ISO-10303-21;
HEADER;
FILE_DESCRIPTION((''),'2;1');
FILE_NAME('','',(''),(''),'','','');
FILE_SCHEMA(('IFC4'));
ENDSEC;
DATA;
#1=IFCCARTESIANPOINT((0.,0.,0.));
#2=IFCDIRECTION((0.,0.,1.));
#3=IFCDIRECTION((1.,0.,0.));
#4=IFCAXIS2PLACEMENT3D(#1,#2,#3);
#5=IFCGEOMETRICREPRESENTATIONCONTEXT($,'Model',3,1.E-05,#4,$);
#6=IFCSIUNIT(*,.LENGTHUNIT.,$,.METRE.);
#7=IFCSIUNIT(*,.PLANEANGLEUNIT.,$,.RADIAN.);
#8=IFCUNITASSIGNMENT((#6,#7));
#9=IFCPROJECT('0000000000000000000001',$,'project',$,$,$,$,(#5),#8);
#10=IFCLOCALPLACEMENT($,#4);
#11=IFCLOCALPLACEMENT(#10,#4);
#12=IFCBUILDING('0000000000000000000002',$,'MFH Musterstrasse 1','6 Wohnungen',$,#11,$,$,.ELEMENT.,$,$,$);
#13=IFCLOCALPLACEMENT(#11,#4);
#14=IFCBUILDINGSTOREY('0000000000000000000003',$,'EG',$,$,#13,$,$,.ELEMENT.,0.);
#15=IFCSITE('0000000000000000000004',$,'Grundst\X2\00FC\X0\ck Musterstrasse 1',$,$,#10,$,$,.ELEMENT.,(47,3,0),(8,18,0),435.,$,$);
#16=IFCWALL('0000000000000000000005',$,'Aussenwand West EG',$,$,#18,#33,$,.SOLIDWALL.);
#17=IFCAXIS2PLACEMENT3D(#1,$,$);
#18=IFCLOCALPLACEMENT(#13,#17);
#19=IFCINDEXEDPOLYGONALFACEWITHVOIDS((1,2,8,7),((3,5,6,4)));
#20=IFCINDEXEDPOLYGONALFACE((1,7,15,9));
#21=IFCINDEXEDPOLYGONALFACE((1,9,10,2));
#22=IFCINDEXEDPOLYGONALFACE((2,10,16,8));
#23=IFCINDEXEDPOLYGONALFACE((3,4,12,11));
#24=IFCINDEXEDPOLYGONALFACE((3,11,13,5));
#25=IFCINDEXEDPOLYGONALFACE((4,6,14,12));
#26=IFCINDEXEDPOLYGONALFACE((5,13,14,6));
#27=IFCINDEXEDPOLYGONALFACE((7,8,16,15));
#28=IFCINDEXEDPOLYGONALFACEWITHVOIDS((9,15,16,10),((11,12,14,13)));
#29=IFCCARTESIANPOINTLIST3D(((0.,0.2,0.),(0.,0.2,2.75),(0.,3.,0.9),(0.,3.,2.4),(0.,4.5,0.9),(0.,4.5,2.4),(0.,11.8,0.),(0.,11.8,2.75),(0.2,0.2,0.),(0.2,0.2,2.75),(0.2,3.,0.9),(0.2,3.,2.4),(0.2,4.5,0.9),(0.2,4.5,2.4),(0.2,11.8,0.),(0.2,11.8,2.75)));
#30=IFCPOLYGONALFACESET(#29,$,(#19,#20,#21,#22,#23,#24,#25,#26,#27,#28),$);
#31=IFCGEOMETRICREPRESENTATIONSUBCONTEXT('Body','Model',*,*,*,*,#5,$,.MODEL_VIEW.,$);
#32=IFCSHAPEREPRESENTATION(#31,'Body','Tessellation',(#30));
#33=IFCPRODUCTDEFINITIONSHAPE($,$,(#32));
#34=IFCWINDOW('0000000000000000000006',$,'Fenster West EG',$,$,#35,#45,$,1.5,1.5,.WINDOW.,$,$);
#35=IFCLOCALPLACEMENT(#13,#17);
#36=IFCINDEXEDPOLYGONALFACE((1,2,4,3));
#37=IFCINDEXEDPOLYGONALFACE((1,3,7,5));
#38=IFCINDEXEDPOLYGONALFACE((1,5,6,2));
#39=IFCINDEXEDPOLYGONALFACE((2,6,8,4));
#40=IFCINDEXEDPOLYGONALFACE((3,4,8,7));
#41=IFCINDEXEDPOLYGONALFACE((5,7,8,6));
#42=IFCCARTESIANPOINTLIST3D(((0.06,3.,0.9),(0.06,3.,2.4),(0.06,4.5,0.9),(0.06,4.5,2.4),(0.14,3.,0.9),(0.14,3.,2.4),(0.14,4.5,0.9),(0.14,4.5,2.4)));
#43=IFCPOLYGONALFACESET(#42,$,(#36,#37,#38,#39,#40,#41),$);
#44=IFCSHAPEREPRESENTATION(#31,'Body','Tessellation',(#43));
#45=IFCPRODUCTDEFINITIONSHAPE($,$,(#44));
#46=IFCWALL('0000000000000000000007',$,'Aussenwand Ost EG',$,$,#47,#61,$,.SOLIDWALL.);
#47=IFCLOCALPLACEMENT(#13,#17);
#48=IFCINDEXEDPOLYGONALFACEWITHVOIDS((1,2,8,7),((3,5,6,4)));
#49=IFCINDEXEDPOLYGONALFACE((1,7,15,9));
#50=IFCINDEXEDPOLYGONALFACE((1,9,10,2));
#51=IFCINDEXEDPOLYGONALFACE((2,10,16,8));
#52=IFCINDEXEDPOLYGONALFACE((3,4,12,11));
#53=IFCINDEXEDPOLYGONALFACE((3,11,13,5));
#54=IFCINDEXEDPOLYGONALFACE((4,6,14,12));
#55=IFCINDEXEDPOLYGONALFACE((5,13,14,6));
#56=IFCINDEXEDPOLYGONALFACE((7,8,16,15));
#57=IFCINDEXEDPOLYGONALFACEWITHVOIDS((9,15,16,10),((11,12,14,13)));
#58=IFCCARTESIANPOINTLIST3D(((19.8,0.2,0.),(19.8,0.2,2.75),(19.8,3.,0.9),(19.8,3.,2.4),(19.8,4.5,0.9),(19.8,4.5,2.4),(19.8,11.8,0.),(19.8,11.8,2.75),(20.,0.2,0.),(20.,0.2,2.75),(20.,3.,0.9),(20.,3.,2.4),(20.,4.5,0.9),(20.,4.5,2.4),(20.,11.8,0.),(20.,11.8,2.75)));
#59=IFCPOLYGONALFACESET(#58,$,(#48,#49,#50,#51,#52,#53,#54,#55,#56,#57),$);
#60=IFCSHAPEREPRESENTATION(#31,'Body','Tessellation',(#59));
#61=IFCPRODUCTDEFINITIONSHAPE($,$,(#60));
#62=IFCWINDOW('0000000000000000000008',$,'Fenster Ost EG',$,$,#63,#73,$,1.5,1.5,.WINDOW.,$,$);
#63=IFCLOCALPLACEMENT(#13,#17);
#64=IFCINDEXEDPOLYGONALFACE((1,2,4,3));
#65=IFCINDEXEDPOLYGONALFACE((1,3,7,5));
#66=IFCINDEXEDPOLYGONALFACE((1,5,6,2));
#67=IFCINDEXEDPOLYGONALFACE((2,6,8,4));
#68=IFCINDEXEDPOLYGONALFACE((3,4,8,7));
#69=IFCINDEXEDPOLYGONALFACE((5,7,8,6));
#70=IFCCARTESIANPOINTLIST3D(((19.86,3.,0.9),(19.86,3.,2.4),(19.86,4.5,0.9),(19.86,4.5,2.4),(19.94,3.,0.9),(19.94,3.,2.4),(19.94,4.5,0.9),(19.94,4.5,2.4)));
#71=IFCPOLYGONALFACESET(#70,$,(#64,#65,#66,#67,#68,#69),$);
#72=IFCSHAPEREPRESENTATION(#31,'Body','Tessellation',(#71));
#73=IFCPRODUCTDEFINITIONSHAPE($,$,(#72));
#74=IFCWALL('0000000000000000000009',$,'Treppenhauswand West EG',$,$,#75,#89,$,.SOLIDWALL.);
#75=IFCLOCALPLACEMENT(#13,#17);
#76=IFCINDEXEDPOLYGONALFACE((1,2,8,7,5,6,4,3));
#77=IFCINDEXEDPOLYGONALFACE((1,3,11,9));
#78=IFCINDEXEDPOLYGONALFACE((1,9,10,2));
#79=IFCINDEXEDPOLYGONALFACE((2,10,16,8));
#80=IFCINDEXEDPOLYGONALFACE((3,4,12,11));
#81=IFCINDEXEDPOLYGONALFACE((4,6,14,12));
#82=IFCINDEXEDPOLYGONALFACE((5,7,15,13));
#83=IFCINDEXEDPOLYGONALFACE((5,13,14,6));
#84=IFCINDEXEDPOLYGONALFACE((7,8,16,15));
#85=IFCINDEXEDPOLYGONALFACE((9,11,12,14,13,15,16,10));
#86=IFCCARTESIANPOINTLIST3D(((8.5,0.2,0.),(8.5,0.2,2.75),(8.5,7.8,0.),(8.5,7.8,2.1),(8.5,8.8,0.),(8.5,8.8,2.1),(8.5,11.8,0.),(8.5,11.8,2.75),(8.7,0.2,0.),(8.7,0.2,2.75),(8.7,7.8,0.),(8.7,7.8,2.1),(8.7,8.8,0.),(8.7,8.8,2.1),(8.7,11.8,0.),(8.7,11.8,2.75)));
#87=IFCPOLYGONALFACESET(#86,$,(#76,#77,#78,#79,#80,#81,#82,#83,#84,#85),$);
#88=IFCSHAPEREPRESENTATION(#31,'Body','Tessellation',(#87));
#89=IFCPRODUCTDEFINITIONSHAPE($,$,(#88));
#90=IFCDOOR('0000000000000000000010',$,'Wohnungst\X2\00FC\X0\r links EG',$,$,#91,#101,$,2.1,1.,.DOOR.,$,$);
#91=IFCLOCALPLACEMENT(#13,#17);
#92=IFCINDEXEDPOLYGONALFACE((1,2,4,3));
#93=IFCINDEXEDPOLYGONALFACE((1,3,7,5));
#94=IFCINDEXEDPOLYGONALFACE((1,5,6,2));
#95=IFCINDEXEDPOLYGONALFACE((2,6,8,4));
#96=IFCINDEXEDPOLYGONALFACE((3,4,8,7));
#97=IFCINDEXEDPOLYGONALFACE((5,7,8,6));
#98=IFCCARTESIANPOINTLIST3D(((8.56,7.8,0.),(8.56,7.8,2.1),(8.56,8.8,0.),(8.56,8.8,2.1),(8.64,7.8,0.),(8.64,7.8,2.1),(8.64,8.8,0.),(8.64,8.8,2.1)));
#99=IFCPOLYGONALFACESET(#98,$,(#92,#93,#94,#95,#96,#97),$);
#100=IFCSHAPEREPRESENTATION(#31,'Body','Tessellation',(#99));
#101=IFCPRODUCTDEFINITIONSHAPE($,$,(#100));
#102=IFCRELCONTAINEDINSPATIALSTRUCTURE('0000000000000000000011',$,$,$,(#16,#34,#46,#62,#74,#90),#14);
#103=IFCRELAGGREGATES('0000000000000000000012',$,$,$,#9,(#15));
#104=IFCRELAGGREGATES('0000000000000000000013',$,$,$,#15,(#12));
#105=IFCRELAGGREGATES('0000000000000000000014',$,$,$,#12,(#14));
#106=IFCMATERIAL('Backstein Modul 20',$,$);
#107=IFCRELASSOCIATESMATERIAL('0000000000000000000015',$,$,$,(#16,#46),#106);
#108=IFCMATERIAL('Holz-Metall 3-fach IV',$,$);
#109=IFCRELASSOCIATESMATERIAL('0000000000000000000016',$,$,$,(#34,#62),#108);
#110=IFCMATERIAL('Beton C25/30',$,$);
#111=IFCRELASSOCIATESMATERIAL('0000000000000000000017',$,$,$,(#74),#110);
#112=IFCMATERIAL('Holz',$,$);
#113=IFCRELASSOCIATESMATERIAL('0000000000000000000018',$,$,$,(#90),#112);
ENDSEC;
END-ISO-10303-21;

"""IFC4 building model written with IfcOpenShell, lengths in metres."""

from ifc_helpers import new_model, si_unit, frame, frame_2d, origin_with_axes, place, context, subcontext, project, spatial, rectangle, extrude, material, element, fill, save


model = new_model("IFC4")

# Units and contexts
model_context = context("Model", 3, precision=1e-05, world=origin_with_axes())
body_context = subcontext(model_context, "Body", "Model", "MODEL_VIEW")
ifc_project = project(units=[si_unit("LENGTHUNIT", "METRE"), si_unit("PLANEANGLEUNIT", "RADIAN")], contexts=[model_context])

# Site, building, storey
site_placement = place(None, origin_with_axes())
site = spatial("IfcSite", under=ifc_project, at=site_placement, Name="Grundstück Musterstrasse 1", CompositionType="ELEMENT", RefLatitude=(47, 3, 0), RefLongitude=(8, 18, 0), RefElevation=435.0)
building_placement = place(site_placement, origin_with_axes())
building = spatial("IfcBuilding", under=site, at=building_placement, Name="MFH Musterstrasse 1", Description="6 Wohnungen", CompositionType="ELEMENT")
storey_placement = place(building_placement, origin_with_axes())
storey = spatial("IfcBuildingStorey", under=building, at=storey_placement, Name="EG", CompositionType="ELEMENT", Elevation=0.0)

# Walls, openings, windows
ifc_material_1 = material(Name="Backstein Modul 20")
wall_1_placement = place(storey_placement, origin_with_axes())
wall_1 = element("IfcWall", 1, at=wall_1_placement, inside=storey, material=ifc_material_1, Name="Aussenwand West EG", PredefinedType="SOLIDWALL", context=body_context, shape_type="SweptSolid", body=[
    extrude(rectangle(XDim=0.2, YDim=11.6, at=frame_2d((0.1, 5.8), x_axis=(1.0, 0.0))), frame((0.0, 0.2, 0.0), z_axis=(0.0, 0.0, 1.0), x_axis=(1.0, 0.0, 0.0)), (0.0, 0.0, 1.0), 2.75),
])
opening_1_placement = place(storey_placement, origin_with_axes())
element("IfcOpeningElement", 2, at=opening_1_placement, cuts=wall_1, PredefinedType="OPENING", context=body_context, shape_type="SweptSolid", body=[
    extrude(rectangle(XDim=0.3, YDim=1.5, at=frame_2d((0.15, 0.75), x_axis=(1.0, 0.0))), frame((-0.05, 3.0, 0.9), z_axis=(0.0, 0.0, 1.0), x_axis=(1.0, 0.0, 0.0)), (0.0, 0.0, 1.0), 1.5),
])
opening_2_placement = place(storey_placement, origin_with_axes())
opening_2 = element("IfcOpeningElement", 3, at=opening_2_placement, cuts=wall_1, PredefinedType="OPENING", context=body_context, shape_type="SweptSolid", body=[
    extrude(rectangle(XDim=0.22, YDim=1.5, at=frame_2d((0.11, 0.75), x_axis=(1.0, 0.0))), frame((-0.01, 3.0, 0.9), z_axis=(0.0, 0.0, 1.0), x_axis=(1.0, 0.0, 0.0)), (0.0, 0.0, 1.0), 1.5),
])
ifc_material_2 = material(Name="Holz-Metall 3-fach IV")
window_1_placement = place(storey_placement, origin_with_axes())
window_1 = element("IfcWindow", 4, at=window_1_placement, inside=storey, material=ifc_material_2, Name="Fenster West EG", OverallHeight=1.5, OverallWidth=1.5, PredefinedType="WINDOW", context=body_context, shape_type="SweptSolid", body=[
    extrude(rectangle(XDim=0.08, YDim=1.5, at=frame_2d((0.04, 0.75), x_axis=(1.0, 0.0))), frame((0.06, 3.0, 0.9), z_axis=(0.0, 0.0, 1.0), x_axis=(1.0, 0.0, 0.0)), (0.0, 0.0, 1.0), 1.5),
])
fill(opening_2, window_1)
wall_2_placement = place(storey_placement, origin_with_axes())
wall_2 = element("IfcWall", 5, at=wall_2_placement, inside=storey, material=ifc_material_1, Name="Aussenwand Ost EG", PredefinedType="SOLIDWALL", context=body_context, shape_type="SweptSolid", body=[
    extrude(rectangle(XDim=0.2, YDim=11.6, at=frame_2d((0.1, 5.8), x_axis=(1.0, 0.0))), frame((19.8, 0.2, 0.0), z_axis=(0.0, 0.0, 1.0), x_axis=(1.0, 0.0, 0.0)), (0.0, 0.0, 1.0), 2.75),
])
opening_3_placement = place(storey_placement, origin_with_axes())
element("IfcOpeningElement", 6, at=opening_3_placement, cuts=wall_2, PredefinedType="OPENING", context=body_context, shape_type="SweptSolid", body=[
    extrude(rectangle(XDim=0.3, YDim=1.5, at=frame_2d((0.15, 0.75), x_axis=(1.0, 0.0))), frame((19.75, 3.0, 0.9), z_axis=(0.0, 0.0, 1.0), x_axis=(1.0, 0.0, 0.0)), (0.0, 0.0, 1.0), 1.5),
])
opening_4_placement = place(storey_placement, origin_with_axes())
opening_4 = element("IfcOpeningElement", 7, at=opening_4_placement, cuts=wall_2, PredefinedType="OPENING", context=body_context, shape_type="SweptSolid", body=[
    extrude(rectangle(XDim=0.22, YDim=1.5, at=frame_2d((0.11, 0.75), x_axis=(1.0, 0.0))), frame((19.79, 3.0, 0.9), z_axis=(0.0, 0.0, 1.0), x_axis=(1.0, 0.0, 0.0)), (0.0, 0.0, 1.0), 1.5),
])
window_2_placement = place(storey_placement, origin_with_axes())
window_2 = element("IfcWindow", 8, at=window_2_placement, inside=storey, material=ifc_material_2, Name="Fenster Ost EG", OverallHeight=1.5, OverallWidth=1.5, PredefinedType="WINDOW", context=body_context, shape_type="SweptSolid", body=[
    extrude(rectangle(XDim=0.08, YDim=1.5, at=frame_2d((0.04, 0.75), x_axis=(1.0, 0.0))), frame((19.86, 3.0, 0.9), z_axis=(0.0, 0.0, 1.0), x_axis=(1.0, 0.0, 0.0)), (0.0, 0.0, 1.0), 1.5),
])
fill(opening_4, window_2)

# Wall, openings, door
ifc_material_3 = material(Name="Beton C25/30")
wall_3_placement = place(storey_placement, origin_with_axes())
wall_3 = element("IfcWall", 9, at=wall_3_placement, inside=storey, material=ifc_material_3, Name="Treppenhauswand West EG", PredefinedType="SOLIDWALL", context=body_context, shape_type="SweptSolid", body=[
    extrude(rectangle(XDim=0.2, YDim=11.6, at=frame_2d((0.1, 5.8), x_axis=(1.0, 0.0))), frame((8.5, 0.2, 0.0), z_axis=(0.0, 0.0, 1.0), x_axis=(1.0, 0.0, 0.0)), (0.0, 0.0, 1.0), 2.75),
])
opening_5_placement = place(storey_placement, origin_with_axes())
element("IfcOpeningElement", 10, at=opening_5_placement, cuts=wall_3, PredefinedType="OPENING", context=body_context, shape_type="SweptSolid", body=[
    extrude(rectangle(XDim=0.3, YDim=1.0, at=frame_2d((0.15, 0.5), x_axis=(1.0, 0.0))), frame((8.45, 7.8, 0.0), z_axis=(0.0, 0.0, 1.0), x_axis=(1.0, 0.0, 0.0)), (0.0, 0.0, 1.0), 2.1),
])
opening_6_placement = place(storey_placement, origin_with_axes())
opening_6 = element("IfcOpeningElement", 11, at=opening_6_placement, cuts=wall_3, PredefinedType="OPENING", context=body_context, shape_type="SweptSolid", body=[
    extrude(rectangle(XDim=0.22, YDim=1.0, at=frame_2d((0.11, 0.5), x_axis=(1.0, 0.0))), frame((8.49, 7.8, 0.0), z_axis=(0.0, 0.0, 1.0), x_axis=(1.0, 0.0, 0.0)), (0.0, 0.0, 1.0), 2.1),
])
ifc_material_4 = material(Name="Holz")
door_placement = place(storey_placement, origin_with_axes())
door = element("IfcDoor", 12, at=door_placement, inside=storey, material=ifc_material_4, Name="Wohnungstür links EG", OverallHeight=2.1, OverallWidth=1.0, PredefinedType="DOOR", context=body_context, shape_type="SweptSolid", body=[
    extrude(rectangle(XDim=0.08, YDim=1.0, at=frame_2d((0.04, 0.5), x_axis=(1.0, 0.0))), frame((8.56, 7.8, 0.0), z_axis=(0.0, 0.0, 1.0), x_axis=(1.0, 0.0, 0.0)), (0.0, 0.0, 1.0), 2.1),
])
fill(opening_6, door)

save(model, "model.ifc")
